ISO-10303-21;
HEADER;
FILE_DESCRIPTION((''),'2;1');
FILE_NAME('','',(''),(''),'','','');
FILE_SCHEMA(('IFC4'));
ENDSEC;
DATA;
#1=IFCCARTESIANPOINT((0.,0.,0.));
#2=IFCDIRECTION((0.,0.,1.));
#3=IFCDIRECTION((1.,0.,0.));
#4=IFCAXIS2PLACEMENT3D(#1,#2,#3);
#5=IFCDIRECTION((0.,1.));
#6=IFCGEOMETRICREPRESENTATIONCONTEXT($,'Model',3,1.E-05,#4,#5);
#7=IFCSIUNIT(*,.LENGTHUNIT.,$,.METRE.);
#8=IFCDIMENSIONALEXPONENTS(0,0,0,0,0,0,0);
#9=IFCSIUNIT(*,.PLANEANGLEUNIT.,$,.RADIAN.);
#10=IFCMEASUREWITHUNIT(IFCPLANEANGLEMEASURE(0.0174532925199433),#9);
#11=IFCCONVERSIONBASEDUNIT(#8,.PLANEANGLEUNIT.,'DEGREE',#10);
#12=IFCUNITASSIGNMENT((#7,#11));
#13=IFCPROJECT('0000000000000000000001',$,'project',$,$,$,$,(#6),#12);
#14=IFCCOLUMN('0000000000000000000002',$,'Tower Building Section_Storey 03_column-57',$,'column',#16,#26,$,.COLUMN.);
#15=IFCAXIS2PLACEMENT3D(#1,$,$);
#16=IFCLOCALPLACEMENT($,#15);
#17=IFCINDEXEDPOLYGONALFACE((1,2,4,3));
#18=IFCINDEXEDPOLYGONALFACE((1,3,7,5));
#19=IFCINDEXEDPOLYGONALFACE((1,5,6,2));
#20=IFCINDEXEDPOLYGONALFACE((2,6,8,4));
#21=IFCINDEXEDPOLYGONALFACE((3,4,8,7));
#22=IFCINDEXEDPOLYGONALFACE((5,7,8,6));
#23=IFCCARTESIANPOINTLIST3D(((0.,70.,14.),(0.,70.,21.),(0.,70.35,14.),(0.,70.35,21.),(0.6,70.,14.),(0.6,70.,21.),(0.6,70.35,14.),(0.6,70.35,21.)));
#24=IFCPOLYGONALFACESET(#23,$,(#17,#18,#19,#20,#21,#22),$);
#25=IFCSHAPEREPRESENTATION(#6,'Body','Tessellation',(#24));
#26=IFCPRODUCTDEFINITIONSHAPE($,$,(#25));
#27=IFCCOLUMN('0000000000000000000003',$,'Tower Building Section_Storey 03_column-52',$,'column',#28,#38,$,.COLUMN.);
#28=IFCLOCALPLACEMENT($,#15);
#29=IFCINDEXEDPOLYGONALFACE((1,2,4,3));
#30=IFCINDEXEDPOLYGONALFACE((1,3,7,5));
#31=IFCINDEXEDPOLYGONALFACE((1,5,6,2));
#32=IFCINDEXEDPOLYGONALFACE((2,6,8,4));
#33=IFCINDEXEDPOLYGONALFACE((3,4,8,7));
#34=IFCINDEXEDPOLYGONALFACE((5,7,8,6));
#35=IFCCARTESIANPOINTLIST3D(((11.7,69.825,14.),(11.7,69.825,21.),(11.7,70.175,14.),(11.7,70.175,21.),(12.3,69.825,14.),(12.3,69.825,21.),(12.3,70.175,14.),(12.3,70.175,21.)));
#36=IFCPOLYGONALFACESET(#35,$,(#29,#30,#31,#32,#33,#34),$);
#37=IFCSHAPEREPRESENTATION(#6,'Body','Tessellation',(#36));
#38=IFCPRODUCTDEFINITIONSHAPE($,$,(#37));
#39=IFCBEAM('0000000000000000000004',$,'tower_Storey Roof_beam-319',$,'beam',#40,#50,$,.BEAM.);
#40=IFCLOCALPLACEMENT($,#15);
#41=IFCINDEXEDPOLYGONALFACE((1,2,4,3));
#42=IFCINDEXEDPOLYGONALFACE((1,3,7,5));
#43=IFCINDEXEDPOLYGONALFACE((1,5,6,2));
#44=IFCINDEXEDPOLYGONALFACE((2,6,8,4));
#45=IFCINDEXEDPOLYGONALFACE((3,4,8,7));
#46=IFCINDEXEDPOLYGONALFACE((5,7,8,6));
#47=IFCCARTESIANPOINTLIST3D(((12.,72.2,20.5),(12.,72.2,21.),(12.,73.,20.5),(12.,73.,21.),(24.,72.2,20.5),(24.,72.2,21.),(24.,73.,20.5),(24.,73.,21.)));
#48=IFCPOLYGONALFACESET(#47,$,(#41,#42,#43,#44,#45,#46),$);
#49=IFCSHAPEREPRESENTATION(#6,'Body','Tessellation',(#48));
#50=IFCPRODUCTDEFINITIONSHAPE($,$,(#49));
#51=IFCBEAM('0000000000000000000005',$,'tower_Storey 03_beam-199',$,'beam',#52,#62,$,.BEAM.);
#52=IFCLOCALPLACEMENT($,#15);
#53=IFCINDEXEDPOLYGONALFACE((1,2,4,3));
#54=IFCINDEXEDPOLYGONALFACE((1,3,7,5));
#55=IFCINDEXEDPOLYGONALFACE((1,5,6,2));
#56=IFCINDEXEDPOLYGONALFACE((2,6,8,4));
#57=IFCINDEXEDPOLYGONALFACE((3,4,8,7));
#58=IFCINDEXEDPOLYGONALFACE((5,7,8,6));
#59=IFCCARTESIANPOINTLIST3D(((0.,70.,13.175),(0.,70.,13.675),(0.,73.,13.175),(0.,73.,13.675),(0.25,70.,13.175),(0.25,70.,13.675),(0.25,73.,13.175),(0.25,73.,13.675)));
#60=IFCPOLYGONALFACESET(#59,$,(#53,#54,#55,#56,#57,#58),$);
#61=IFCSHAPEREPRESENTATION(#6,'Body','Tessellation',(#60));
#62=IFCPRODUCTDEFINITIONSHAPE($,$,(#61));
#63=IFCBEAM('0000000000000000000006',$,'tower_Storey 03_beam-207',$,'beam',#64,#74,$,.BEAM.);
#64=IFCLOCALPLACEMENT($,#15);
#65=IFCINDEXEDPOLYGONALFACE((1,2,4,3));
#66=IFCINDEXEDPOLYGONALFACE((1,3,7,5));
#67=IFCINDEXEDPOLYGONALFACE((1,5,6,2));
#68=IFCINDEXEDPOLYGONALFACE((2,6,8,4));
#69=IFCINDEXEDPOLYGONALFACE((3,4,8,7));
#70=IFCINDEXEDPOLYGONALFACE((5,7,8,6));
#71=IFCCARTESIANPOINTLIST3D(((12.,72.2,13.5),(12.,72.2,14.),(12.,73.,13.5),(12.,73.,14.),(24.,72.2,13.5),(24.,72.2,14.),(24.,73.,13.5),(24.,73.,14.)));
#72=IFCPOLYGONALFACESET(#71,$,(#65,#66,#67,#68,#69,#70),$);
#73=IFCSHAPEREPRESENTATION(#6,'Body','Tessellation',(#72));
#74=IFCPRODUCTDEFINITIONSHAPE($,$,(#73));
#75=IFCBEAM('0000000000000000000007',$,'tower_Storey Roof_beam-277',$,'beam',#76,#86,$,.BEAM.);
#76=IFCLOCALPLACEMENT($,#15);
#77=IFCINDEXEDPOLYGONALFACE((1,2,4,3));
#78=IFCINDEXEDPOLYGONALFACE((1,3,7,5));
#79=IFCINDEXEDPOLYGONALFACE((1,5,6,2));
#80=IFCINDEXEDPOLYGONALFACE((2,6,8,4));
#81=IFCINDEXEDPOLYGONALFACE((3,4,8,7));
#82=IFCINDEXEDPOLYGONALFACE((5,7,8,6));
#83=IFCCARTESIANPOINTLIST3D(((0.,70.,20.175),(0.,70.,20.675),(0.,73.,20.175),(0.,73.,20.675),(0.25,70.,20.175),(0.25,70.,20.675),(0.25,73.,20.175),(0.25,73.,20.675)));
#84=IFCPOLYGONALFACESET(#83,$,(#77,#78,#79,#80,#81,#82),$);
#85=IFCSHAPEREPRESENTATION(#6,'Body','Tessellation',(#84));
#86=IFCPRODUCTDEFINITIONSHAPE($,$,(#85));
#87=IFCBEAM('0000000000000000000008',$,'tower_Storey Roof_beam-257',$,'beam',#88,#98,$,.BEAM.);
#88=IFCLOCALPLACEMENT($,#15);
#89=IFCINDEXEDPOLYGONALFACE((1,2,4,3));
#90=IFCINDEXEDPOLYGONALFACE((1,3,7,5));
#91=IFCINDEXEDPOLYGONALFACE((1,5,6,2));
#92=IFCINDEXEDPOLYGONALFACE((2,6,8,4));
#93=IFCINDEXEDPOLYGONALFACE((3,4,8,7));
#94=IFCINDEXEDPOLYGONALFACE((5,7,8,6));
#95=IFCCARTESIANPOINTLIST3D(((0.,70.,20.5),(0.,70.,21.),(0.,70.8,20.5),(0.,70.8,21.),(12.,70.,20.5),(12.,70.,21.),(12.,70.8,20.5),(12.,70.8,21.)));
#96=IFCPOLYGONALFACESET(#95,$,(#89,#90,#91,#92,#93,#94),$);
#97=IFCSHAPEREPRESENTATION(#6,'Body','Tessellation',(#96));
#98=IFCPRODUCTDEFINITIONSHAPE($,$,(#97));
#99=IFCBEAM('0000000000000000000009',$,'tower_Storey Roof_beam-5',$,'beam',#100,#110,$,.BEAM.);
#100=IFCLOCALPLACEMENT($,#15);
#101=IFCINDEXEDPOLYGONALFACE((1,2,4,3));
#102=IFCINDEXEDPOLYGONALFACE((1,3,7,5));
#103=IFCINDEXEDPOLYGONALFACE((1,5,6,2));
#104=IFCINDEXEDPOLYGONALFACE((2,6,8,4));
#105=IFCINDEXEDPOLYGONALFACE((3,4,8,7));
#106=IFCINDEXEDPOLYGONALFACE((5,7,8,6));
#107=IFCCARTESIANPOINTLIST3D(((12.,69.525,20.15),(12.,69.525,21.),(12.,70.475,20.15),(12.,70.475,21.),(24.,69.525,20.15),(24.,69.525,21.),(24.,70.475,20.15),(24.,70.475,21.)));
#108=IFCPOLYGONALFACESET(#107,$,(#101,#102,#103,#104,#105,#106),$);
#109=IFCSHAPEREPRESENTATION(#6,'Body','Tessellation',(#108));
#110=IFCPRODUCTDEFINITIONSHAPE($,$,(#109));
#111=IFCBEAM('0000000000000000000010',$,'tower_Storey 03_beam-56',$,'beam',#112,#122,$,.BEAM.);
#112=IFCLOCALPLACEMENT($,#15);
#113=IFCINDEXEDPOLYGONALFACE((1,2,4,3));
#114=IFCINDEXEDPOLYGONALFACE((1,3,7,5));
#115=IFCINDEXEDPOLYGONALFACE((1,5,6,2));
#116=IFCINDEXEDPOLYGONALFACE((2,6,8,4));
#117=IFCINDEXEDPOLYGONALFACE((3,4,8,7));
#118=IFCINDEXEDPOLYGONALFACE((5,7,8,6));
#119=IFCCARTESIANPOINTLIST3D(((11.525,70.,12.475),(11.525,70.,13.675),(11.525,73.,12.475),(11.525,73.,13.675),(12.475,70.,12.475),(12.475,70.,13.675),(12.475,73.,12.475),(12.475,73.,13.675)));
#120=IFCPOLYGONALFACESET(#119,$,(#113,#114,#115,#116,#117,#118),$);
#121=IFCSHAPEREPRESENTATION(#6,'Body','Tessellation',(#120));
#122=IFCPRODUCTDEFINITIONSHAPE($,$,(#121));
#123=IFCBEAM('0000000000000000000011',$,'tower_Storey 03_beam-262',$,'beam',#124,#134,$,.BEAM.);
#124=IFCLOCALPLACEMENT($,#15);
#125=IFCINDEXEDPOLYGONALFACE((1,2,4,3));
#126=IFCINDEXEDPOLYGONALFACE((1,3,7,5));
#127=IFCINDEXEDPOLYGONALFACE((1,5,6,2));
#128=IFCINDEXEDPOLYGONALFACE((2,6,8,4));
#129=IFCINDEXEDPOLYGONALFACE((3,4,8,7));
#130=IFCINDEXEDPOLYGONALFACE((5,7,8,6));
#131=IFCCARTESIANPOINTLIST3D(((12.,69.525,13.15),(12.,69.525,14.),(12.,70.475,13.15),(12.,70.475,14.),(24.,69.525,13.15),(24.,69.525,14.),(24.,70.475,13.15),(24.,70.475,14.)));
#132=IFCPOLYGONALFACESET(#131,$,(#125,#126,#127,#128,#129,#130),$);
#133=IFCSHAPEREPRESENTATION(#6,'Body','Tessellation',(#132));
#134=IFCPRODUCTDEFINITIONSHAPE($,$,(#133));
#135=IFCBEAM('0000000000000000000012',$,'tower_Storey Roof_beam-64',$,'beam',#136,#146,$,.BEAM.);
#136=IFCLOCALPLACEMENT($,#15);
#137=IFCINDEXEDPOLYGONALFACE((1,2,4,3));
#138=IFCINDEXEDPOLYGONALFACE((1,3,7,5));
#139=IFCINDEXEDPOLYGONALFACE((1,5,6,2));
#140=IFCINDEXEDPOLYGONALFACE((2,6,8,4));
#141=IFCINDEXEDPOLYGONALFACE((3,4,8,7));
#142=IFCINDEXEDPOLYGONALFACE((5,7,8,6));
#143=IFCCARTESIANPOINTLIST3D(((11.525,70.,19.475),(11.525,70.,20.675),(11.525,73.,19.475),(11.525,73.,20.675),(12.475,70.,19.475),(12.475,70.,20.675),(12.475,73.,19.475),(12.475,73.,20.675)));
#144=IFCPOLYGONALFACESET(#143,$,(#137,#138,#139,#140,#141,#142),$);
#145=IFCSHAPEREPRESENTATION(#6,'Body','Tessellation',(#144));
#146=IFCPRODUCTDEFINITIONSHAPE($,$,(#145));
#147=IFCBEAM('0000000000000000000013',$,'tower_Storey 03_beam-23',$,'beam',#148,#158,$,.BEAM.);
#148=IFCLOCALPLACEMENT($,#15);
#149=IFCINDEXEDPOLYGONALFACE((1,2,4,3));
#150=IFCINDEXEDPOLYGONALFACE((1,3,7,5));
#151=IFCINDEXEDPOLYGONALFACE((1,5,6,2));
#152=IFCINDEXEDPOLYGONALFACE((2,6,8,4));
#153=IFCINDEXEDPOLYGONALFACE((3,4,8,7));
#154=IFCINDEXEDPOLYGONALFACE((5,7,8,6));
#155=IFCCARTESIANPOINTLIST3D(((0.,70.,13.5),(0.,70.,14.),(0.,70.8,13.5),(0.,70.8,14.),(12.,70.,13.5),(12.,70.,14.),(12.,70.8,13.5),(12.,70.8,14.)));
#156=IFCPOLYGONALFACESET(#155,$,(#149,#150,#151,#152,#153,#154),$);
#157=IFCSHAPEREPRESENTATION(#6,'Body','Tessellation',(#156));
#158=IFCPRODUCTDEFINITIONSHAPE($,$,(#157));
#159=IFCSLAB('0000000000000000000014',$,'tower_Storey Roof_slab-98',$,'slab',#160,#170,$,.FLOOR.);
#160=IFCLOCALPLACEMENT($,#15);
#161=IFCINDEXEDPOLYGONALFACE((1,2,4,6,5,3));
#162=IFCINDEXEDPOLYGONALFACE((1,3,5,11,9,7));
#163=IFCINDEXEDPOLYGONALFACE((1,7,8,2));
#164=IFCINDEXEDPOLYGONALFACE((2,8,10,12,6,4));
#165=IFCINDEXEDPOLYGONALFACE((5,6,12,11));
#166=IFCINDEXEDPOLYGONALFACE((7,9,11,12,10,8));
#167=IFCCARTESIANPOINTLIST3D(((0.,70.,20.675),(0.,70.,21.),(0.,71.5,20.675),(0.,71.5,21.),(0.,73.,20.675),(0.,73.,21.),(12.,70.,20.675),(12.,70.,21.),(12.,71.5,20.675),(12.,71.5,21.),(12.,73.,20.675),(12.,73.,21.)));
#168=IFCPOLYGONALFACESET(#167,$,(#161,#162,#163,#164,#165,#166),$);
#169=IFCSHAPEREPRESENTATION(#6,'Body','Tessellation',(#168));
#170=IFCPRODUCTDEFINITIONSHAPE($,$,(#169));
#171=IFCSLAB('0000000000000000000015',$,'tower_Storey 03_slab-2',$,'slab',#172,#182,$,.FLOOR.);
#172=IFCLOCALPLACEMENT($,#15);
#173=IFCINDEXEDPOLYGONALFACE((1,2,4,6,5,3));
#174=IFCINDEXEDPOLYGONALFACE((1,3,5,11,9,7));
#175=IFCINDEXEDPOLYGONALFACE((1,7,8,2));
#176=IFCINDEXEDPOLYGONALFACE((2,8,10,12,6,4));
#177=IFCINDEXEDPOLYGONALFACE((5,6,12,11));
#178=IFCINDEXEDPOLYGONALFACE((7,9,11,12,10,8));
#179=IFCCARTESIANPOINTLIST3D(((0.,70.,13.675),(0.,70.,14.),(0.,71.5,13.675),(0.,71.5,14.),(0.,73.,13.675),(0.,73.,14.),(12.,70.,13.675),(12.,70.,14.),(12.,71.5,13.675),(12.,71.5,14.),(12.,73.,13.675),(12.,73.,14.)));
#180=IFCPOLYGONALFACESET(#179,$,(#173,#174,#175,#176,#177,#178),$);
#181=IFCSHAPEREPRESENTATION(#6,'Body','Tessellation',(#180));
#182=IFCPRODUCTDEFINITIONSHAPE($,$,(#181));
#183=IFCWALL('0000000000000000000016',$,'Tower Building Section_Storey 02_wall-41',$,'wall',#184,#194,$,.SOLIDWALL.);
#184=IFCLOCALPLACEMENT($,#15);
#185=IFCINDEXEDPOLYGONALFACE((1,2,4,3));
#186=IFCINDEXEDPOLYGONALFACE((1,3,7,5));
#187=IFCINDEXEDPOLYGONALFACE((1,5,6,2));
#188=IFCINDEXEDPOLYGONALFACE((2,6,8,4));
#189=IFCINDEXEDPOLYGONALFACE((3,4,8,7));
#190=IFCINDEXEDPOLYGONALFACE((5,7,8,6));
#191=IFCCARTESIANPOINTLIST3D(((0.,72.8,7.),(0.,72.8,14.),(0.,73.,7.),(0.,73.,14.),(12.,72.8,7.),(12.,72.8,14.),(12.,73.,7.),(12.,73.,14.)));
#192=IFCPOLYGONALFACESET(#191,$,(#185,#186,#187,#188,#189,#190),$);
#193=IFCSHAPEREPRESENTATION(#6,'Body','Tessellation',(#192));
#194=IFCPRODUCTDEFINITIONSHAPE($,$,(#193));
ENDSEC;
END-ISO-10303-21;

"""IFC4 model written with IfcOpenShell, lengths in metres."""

from ifc_helpers import new_model, entity, si_unit, converted_unit, direction, frame, origin_with_axes, place, context, project, polyline, outline, extrude, element, save


model = new_model("IFC4")

# Units and contexts
model_context = context("Model", 3, precision=1e-05, world=origin_with_axes(), true_north=direction((0.0, 1.0)))
ifc_project = project(units=[si_unit("LENGTHUNIT", "METRE"), converted_unit("PLANEANGLEUNIT", "DEGREE", entity("IfcPlaneAngleMeasure", 0.0174532925199433), si_unit("PLANEANGLEUNIT", "RADIAN"), dimensions=[0, 0, 0, 0, 0, 0, 0])], contexts=[model_context])

# Columns
placement_1 = place(None, origin_with_axes())
placement_2 = place(placement_1, frame((0.0, 0.0, 14.0), z_axis=(0.0, 0.0, 1.0), x_axis=(1.0, 0.0, 0.0)))
for number, where, z_axis, x_axis, name in (
    (1, (0.3, 70.175, 0.0), (0.0, 0.0, 1.0), (1.0, 0.0, 0.0), "Tower Building Section_Storey 03_column-57"),
    (2, (12.0, 70.0, 0.0), (0.0, 0.0, 1.0), (1.0, 0.0, 0.0), "Tower Building Section_Storey 03_column-52"),
):
    element("IfcColumn", number, at=place(placement_2, frame(where, z_axis=z_axis, x_axis=x_axis)), Name=name, ObjectType="column", PredefinedType="COLUMN", context=model_context, body=[
        extrude(outline(polyline([(-0.3, -0.175, 0.0), (0.3, -0.175, 0.0), (0.3, 0.175, 0.0), (-0.3, 0.175, 0.0), (-0.3, -0.175, 0.0)])), origin_with_axes(), (0.0, 0.0, 1.0), 7.0),
    ])

# Beams
placement_3 = place(placement_1, frame((0.0, 0.0, 21.0), z_axis=(0.0, 0.0, 1.0), x_axis=(1.0, 0.0, 0.0)))
beam_1_placement = place(placement_3, frame((12.0, 72.6, -0.25), z_axis=(1.0, 0.0, 0.0), x_axis=(0.0, 1.0, 0.0)))
element("IfcBeam", 3, at=beam_1_placement, Name="tower_Storey Roof_beam-319", ObjectType="beam", PredefinedType="BEAM", context=model_context, body=[
    extrude(outline(polyline([(0.4, 0.25, 0.0), (-0.4, 0.25, 0.0), (-0.4, -0.25, 0.0), (0.4, -0.25, 0.0), (0.4, 0.25, 0.0)])), origin_with_axes(), (0.0, 0.0, 1.0), 12.0),
])
beam_2_placement = place(placement_2, frame((0.125, 70.0, -0.575), z_axis=(0.0, 1.0, 0.0), x_axis=(-1.0, 0.0, 0.0)))
element("IfcBeam", 4, at=beam_2_placement, Name="tower_Storey 03_beam-199", ObjectType="beam", PredefinedType="BEAM", context=model_context, body=[
    extrude(outline(polyline([(0.125, 0.25, 0.0), (-0.125, 0.25, 0.0), (-0.125, -0.25, 0.0), (0.125, -0.25, 0.0), (0.125, 0.25, 0.0)])), origin_with_axes(), (0.0, 0.0, 1.0), 3.0),
])
beam_3_placement = place(placement_2, frame((12.0, 72.6, -0.25), z_axis=(1.0, 0.0, 0.0), x_axis=(0.0, 1.0, 0.0)))
element("IfcBeam", 5, at=beam_3_placement, Name="tower_Storey 03_beam-207", ObjectType="beam", PredefinedType="BEAM", context=model_context, body=[
    extrude(outline(polyline([(0.4, 0.25, 0.0), (-0.4, 0.25, 0.0), (-0.4, -0.25, 0.0), (0.4, -0.25, 0.0), (0.4, 0.25, 0.0)])), origin_with_axes(), (0.0, 0.0, 1.0), 12.0),
])
beam_4_placement = place(placement_3, frame((0.125, 70.0, -0.575), z_axis=(0.0, 1.0, 0.0), x_axis=(-1.0, 0.0, 0.0)))
element("IfcBeam", 6, at=beam_4_placement, Name="tower_Storey Roof_beam-277", ObjectType="beam", PredefinedType="BEAM", context=model_context, body=[
    extrude(outline(polyline([(0.125, 0.25, 0.0), (-0.125, 0.25, 0.0), (-0.125, -0.25, 0.0), (0.125, -0.25, 0.0), (0.125, 0.25, 0.0)])), origin_with_axes(), (0.0, 0.0, 1.0), 3.0),
])
beam_5_placement = place(placement_3, frame((0.0, 70.4, -0.25), z_axis=(1.0, 0.0, 0.0), x_axis=(0.0, 1.0, 0.0)))
element("IfcBeam", 7, at=beam_5_placement, Name="tower_Storey Roof_beam-257", ObjectType="beam", PredefinedType="BEAM", context=model_context, body=[
    extrude(outline(polyline([(0.4, 0.25, 0.0), (-0.4, 0.25, 0.0), (-0.4, -0.25, 0.0), (0.4, -0.25, 0.0), (0.4, 0.25, 0.0)])), origin_with_axes(), (0.0, 0.0, 1.0), 12.0),
])
beam_6_placement = place(placement_3, frame((12.0, 70.0, -0.425), z_axis=(1.0, 0.0, 0.0), x_axis=(0.0, 1.0, 0.0)))
element("IfcBeam", 8, at=beam_6_placement, Name="tower_Storey Roof_beam-5", ObjectType="beam", PredefinedType="BEAM", context=model_context, body=[
    extrude(outline(polyline([(0.475, 0.425, 0.0), (-0.475, 0.425, 0.0), (-0.475, -0.425, 0.0), (0.475, -0.425, 0.0), (0.475, 0.425, 0.0)])), origin_with_axes(), (0.0, 0.0, 1.0), 12.0),
])
beam_7_placement = place(placement_2, frame((12.0, 70.0, -0.925), z_axis=(0.0, 1.0, 0.0), x_axis=(-1.0, 0.0, 0.0)))
element("IfcBeam", 9, at=beam_7_placement, Name="tower_Storey 03_beam-56", ObjectType="beam", PredefinedType="BEAM", context=model_context, body=[
    extrude(outline(polyline([(0.475, 0.6, 0.0), (-0.475, 0.6, 0.0), (-0.475, -0.6, 0.0), (0.475, -0.6, 0.0), (0.475, 0.6, 0.0)])), origin_with_axes(), (0.0, 0.0, 1.0), 3.0),
])
beam_8_placement = place(placement_2, frame((12.0, 70.0, -0.425), z_axis=(1.0, 0.0, 0.0), x_axis=(0.0, 1.0, 0.0)))
element("IfcBeam", 10, at=beam_8_placement, Name="tower_Storey 03_beam-262", ObjectType="beam", PredefinedType="BEAM", context=model_context, body=[
    extrude(outline(polyline([(0.475, 0.425, 0.0), (-0.475, 0.425, 0.0), (-0.475, -0.425, 0.0), (0.475, -0.425, 0.0), (0.475, 0.425, 0.0)])), origin_with_axes(), (0.0, 0.0, 1.0), 12.0),
])
beam_9_placement = place(placement_3, frame((12.0, 70.0, -0.925), z_axis=(0.0, 1.0, 0.0), x_axis=(-1.0, 0.0, 0.0)))
element("IfcBeam", 11, at=beam_9_placement, Name="tower_Storey Roof_beam-64", ObjectType="beam", PredefinedType="BEAM", context=model_context, body=[
    extrude(outline(polyline([(0.475, 0.6, 0.0), (-0.475, 0.6, 0.0), (-0.475, -0.6, 0.0), (0.475, -0.6, 0.0), (0.475, 0.6, 0.0)])), origin_with_axes(), (0.0, 0.0, 1.0), 3.0),
])
beam_10_placement = place(placement_2, frame((0.0, 70.4, -0.25), z_axis=(1.0, 0.0, 0.0), x_axis=(0.0, 1.0, 0.0)))
element("IfcBeam", 12, at=beam_10_placement, Name="tower_Storey 03_beam-23", ObjectType="beam", PredefinedType="BEAM", context=model_context, body=[
    extrude(outline(polyline([(0.4, 0.25, 0.0), (-0.4, 0.25, 0.0), (-0.4, -0.25, 0.0), (0.4, -0.25, 0.0), (0.4, 0.25, 0.0)])), origin_with_axes(), (0.0, 0.0, 1.0), 12.0),
])

# Slabs
slab_1_placement = place(placement_3, frame((6.0, 71.5, -0.325), z_axis=(0.0, 0.0, 1.0), x_axis=(1.0, 0.0, 0.0)))
element("IfcSlab", 13, at=slab_1_placement, Name="tower_Storey Roof_slab-98", ObjectType="slab", PredefinedType="FLOOR", context=model_context, body=[
    extrude(outline(polyline([(-6.0, 0.0, 0.0), (-6.0, -1.5, 0.0), (6.0, -1.5, 0.0), (6.0, 0.0, 0.0), (6.0, 1.5, 0.0), (-6.0, 1.5, 0.0), (-6.0, 0.0, 0.0)])), origin_with_axes(), (0.0, 0.0, 1.0), 0.325),
])
slab_2_placement = place(placement_2, frame((6.0, 71.5, -0.325), z_axis=(0.0, 0.0, 1.0), x_axis=(1.0, 0.0, 0.0)))
element("IfcSlab", 14, at=slab_2_placement, Name="tower_Storey 03_slab-2", ObjectType="slab", PredefinedType="FLOOR", context=model_context, body=[
    extrude(outline(polyline([(-6.0, 0.0, 0.0), (-6.0, -1.5, 0.0), (6.0, -1.5, 0.0), (6.0, 0.0, 0.0), (6.0, 1.5, 0.0), (-6.0, 1.5, 0.0), (-6.0, 0.0, 0.0)])), origin_with_axes(), (0.0, 0.0, 1.0), 0.325),
])

# Wall
placement_4 = place(placement_1, frame((0.0, 0.0, 7.0), z_axis=(0.0, 0.0, 1.0), x_axis=(1.0, 0.0, 0.0)))
wall_1_placement = place(placement_4, frame((6.0, 72.8, 3.5), z_axis=(0.0, 1.0, 0.0), x_axis=(0.0, 0.0, 1.0)))
element("IfcWall", 15, at=wall_1_placement, Name="Tower Building Section_Storey 02_wall-41", ObjectType="wall", PredefinedType="SOLIDWALL", context=model_context, body=[
    extrude(outline(polyline([(-3.5, -6.0, 0.0), (3.5, -6.0, 0.0), (3.5, 6.0, 0.0), (-3.5, 6.0, 0.0), (-3.5, -6.0, 0.0)])), origin_with_axes(), (0.0, 0.0, 1.0), 0.2),
])

save(model, "model.ifc")
